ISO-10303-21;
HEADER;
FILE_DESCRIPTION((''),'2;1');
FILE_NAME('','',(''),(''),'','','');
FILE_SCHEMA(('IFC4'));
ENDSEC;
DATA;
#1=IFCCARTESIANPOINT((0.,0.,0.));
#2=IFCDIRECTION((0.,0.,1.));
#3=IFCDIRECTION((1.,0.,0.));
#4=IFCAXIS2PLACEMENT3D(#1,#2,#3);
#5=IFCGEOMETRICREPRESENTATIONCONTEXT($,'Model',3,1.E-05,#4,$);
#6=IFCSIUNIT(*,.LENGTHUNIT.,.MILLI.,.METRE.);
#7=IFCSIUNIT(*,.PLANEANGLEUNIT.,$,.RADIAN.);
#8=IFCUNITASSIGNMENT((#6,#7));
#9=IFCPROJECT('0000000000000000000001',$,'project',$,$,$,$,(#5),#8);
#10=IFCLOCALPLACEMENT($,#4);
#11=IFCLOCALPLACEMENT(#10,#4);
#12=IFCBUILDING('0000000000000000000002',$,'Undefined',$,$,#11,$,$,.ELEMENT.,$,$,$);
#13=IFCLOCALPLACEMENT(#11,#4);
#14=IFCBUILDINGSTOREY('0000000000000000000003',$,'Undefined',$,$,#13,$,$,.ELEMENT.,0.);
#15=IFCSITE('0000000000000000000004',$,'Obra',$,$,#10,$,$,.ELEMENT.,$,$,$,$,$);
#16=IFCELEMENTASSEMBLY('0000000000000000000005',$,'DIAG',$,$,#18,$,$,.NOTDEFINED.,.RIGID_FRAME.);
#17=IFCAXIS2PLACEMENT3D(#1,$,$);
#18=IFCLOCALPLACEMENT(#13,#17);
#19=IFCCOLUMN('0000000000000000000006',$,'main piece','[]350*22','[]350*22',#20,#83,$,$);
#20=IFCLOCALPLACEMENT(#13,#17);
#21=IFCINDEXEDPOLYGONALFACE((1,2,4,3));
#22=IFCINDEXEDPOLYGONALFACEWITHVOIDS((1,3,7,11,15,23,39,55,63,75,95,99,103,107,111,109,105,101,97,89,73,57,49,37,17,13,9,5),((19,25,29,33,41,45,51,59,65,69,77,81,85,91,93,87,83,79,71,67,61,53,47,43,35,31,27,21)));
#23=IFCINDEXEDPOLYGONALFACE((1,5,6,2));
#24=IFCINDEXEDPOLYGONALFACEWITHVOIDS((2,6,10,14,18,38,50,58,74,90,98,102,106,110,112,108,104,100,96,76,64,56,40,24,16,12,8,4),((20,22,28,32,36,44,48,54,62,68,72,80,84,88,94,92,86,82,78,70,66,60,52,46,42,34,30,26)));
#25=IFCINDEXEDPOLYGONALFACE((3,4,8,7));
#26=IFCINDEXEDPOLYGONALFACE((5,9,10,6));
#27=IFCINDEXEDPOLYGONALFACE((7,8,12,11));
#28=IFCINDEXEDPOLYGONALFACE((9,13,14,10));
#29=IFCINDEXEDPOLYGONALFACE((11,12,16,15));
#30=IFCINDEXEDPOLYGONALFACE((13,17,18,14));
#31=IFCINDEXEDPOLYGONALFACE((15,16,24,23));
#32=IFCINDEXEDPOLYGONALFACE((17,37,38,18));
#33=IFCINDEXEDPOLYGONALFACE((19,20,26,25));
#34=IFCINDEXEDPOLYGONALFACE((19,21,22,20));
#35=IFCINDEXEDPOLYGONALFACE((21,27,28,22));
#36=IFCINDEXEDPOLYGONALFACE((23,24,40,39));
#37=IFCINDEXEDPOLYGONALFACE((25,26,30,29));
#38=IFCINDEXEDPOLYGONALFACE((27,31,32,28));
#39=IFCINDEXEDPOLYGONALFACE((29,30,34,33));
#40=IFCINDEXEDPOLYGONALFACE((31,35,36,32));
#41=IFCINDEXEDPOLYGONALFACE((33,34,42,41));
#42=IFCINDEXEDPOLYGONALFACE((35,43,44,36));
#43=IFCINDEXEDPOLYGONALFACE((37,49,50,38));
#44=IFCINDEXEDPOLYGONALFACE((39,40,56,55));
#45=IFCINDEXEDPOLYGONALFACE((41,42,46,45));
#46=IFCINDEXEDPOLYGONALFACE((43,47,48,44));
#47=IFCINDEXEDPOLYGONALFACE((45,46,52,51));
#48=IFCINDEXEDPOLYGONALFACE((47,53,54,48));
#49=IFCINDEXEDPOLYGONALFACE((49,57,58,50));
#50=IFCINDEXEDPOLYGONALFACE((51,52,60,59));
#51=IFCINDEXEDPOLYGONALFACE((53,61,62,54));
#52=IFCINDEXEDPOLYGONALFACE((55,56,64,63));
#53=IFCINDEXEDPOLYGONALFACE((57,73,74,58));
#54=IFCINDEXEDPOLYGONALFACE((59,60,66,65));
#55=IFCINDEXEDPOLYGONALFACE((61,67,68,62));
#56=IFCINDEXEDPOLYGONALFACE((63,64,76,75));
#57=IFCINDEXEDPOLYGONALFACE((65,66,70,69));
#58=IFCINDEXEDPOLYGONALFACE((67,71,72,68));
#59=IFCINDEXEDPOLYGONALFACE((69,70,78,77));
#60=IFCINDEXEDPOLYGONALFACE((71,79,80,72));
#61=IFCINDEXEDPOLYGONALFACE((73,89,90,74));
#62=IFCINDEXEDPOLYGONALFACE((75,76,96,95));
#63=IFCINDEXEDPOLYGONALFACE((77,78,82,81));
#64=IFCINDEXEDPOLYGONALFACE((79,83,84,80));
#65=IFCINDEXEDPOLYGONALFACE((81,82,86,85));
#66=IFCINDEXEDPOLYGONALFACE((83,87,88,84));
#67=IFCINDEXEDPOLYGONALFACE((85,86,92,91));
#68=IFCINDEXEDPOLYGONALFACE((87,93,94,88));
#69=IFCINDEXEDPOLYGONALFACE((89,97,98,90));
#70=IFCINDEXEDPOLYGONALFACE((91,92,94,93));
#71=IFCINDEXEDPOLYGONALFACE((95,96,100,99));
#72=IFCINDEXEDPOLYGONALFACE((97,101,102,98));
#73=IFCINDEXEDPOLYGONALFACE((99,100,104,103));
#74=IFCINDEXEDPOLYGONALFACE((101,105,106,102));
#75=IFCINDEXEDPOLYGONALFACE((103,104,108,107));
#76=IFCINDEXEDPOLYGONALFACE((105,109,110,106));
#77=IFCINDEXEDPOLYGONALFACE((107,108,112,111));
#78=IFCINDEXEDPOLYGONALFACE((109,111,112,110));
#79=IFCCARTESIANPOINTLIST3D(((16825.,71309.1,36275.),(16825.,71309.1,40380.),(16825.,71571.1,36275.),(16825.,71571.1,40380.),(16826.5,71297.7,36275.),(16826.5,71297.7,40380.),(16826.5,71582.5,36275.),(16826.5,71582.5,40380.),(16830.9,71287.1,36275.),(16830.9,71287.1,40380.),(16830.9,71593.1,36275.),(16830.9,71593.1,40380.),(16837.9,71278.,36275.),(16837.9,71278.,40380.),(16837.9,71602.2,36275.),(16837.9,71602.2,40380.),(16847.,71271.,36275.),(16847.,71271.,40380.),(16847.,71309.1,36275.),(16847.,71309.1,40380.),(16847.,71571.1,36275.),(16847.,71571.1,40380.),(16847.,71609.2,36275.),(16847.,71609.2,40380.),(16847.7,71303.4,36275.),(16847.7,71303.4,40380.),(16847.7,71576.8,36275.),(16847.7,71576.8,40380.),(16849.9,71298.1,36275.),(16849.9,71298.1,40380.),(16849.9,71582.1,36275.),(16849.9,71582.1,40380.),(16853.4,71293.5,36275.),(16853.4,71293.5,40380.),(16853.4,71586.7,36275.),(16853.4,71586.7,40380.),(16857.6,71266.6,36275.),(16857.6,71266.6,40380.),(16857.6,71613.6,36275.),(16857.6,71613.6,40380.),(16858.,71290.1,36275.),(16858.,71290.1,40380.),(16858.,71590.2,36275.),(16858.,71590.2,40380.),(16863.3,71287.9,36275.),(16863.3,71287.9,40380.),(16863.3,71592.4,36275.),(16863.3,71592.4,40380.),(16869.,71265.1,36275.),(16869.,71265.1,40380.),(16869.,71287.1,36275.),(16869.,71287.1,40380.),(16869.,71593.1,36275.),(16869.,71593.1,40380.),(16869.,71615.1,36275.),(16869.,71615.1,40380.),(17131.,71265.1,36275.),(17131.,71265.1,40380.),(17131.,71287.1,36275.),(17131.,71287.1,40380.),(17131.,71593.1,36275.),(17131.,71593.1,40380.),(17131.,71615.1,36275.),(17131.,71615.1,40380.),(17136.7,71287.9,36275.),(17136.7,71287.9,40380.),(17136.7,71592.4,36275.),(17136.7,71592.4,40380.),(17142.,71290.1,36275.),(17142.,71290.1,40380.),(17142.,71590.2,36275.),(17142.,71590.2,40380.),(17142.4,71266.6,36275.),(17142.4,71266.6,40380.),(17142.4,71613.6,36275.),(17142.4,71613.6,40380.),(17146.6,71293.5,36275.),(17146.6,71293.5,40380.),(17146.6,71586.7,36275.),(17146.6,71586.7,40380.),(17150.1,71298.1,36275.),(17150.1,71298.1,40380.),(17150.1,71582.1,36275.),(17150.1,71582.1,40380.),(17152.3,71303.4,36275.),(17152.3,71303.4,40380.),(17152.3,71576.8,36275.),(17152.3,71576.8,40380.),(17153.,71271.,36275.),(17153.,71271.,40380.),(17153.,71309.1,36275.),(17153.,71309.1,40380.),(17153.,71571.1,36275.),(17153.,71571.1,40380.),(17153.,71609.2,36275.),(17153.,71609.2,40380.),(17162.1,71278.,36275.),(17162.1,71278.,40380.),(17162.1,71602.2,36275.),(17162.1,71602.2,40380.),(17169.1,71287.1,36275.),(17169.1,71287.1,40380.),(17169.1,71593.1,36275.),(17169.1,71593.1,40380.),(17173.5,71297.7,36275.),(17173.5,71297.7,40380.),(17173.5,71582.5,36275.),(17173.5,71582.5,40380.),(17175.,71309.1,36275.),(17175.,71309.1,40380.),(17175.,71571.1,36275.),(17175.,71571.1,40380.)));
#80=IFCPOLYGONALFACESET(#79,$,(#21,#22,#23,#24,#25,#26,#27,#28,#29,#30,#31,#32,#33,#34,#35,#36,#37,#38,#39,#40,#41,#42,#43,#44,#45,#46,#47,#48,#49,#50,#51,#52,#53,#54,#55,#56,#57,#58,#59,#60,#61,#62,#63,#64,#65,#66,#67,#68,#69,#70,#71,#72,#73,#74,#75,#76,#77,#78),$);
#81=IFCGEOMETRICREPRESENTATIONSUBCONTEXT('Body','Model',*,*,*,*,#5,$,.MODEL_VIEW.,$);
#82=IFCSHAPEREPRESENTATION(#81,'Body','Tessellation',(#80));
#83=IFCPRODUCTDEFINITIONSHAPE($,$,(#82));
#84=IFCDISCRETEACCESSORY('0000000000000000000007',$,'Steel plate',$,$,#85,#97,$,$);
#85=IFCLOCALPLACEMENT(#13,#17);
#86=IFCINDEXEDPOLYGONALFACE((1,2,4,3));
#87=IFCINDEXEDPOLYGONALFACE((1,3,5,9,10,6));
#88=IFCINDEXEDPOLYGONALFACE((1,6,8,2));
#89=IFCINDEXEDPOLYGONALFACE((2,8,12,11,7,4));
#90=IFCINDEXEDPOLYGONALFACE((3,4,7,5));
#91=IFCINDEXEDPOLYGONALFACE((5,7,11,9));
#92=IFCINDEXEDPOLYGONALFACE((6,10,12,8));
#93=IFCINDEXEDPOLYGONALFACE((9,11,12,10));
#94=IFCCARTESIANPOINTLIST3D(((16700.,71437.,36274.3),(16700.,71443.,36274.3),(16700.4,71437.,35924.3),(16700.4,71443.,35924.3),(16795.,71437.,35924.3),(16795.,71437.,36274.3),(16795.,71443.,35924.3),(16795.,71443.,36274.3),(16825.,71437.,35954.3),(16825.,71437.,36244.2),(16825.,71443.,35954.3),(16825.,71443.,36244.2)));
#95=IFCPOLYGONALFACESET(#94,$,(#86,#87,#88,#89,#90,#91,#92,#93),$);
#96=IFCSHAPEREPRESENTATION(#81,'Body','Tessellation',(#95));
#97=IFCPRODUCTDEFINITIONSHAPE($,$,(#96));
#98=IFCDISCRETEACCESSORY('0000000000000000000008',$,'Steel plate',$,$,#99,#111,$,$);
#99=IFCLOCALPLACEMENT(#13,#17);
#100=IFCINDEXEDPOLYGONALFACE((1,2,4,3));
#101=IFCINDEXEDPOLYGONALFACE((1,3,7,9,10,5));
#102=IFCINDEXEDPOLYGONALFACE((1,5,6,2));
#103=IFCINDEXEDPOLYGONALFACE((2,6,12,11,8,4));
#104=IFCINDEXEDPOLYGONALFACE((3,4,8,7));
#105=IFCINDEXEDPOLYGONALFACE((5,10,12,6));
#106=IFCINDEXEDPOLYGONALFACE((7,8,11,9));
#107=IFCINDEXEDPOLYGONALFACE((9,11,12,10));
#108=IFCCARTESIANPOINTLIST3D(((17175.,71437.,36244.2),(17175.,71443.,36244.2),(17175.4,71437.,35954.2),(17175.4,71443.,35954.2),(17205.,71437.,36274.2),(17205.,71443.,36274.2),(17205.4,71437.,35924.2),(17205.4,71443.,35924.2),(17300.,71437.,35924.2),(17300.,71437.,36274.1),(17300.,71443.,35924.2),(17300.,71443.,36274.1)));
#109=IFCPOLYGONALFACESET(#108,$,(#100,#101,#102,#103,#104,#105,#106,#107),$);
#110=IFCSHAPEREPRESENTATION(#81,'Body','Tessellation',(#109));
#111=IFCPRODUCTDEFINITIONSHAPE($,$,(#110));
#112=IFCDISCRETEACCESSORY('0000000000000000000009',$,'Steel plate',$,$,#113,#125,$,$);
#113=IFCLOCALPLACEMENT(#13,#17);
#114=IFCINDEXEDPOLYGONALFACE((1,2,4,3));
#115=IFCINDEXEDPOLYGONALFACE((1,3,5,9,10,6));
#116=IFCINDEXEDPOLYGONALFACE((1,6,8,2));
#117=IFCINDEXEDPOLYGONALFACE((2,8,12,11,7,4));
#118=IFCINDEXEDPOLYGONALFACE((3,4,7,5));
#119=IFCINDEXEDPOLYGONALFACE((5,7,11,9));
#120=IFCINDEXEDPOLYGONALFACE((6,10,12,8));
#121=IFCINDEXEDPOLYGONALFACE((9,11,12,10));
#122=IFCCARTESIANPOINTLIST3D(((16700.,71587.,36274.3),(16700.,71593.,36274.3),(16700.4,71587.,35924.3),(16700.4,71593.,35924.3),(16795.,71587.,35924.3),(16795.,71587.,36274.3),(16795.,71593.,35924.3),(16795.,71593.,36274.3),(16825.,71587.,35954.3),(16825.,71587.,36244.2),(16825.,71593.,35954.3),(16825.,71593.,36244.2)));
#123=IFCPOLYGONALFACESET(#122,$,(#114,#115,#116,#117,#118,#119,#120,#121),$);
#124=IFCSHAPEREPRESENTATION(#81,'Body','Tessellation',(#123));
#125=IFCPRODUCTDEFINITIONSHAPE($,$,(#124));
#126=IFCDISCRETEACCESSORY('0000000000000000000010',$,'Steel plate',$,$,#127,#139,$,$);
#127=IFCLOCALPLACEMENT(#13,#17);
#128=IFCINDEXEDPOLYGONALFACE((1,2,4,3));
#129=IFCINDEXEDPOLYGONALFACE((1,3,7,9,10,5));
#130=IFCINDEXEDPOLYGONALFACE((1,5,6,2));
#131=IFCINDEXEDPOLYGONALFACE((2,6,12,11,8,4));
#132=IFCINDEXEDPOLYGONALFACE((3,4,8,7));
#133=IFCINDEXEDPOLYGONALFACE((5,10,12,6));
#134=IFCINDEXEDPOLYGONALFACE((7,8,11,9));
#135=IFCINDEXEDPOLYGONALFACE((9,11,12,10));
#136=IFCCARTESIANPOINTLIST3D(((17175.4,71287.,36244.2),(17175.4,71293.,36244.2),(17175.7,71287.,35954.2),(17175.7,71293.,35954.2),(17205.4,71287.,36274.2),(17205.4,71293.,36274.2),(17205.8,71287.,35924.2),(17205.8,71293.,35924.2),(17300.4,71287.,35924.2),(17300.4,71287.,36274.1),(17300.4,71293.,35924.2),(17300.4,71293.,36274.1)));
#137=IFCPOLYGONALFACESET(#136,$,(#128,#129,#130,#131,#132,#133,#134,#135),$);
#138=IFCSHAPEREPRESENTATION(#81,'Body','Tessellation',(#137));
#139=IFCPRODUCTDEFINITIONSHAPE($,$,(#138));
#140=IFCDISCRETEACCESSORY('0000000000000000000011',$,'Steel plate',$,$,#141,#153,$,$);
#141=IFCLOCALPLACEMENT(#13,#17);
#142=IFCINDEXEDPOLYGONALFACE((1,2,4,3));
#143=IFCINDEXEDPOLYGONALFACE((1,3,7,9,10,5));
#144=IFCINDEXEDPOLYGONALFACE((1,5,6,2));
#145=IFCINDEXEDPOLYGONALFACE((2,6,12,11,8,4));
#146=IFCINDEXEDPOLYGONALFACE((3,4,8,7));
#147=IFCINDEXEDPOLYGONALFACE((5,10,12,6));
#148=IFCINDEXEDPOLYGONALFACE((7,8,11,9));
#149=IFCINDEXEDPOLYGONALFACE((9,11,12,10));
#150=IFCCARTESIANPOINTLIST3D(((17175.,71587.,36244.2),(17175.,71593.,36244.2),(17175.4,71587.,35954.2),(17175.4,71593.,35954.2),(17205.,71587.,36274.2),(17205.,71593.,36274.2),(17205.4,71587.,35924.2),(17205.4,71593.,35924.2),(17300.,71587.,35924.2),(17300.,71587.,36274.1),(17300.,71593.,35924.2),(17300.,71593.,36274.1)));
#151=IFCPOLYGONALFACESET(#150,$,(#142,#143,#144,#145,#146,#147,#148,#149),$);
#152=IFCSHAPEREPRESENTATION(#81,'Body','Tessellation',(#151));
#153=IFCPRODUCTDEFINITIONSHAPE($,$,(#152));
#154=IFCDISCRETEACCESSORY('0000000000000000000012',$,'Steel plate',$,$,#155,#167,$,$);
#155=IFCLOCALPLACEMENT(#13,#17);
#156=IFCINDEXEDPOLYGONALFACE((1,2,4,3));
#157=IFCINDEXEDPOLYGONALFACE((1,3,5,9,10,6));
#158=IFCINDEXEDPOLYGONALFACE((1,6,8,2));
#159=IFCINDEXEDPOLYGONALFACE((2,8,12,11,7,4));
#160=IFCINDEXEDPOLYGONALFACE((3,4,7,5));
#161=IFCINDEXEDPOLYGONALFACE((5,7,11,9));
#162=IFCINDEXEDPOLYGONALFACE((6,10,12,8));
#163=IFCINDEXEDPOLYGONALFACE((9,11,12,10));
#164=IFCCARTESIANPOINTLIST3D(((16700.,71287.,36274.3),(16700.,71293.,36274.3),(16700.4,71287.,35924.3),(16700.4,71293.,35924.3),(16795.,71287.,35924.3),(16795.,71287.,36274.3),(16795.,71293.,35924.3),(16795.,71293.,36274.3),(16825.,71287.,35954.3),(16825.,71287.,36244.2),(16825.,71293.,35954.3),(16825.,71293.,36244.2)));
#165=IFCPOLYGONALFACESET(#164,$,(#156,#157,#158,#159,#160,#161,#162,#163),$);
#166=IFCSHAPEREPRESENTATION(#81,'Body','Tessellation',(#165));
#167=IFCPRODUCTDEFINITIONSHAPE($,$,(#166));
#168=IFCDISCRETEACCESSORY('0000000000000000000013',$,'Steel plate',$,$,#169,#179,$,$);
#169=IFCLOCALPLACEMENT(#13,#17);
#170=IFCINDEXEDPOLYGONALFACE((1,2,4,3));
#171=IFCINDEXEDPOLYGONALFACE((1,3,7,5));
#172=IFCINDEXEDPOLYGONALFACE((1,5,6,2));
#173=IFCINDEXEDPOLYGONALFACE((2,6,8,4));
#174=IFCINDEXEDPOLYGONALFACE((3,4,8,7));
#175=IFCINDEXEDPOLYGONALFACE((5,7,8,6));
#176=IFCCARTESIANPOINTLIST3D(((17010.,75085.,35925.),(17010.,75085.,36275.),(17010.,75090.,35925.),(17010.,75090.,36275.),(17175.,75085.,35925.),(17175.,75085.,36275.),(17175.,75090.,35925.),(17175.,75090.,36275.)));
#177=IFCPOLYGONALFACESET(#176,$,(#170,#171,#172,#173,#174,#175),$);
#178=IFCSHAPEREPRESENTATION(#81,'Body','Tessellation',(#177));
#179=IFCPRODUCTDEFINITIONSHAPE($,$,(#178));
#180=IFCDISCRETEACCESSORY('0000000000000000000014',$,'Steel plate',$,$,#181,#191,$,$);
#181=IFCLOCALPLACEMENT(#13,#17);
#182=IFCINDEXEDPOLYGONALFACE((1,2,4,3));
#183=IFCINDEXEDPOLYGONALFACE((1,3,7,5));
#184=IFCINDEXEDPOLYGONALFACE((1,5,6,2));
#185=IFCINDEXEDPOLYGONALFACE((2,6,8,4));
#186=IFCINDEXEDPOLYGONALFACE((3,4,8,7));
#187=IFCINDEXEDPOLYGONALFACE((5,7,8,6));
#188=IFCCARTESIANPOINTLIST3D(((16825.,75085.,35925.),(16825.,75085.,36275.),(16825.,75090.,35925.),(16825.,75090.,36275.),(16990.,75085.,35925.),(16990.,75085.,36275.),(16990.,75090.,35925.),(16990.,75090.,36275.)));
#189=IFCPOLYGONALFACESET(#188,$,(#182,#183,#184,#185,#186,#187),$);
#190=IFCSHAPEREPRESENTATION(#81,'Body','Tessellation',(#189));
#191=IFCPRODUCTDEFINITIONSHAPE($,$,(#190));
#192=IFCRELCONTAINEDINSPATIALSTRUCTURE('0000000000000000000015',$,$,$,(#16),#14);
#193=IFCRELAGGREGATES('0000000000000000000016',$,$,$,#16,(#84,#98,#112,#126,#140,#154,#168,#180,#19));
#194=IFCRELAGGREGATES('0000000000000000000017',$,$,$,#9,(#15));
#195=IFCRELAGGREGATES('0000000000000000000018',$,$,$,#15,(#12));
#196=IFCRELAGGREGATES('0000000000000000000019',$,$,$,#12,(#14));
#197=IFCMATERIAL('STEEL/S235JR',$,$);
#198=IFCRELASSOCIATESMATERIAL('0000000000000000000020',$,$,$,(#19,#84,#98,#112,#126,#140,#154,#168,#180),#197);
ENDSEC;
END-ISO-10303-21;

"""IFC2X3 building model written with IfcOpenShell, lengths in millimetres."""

from ifc_helpers import new_model, si_unit, frame, origin_with_axes, origin_2d_with_axis, place, context, subcontext, project, spatial, polyline, hollow_rectangle, outline, extrude, material, element, aggregate, save


model = new_model("IFC2X3")

# Units and contexts
model_context = context("Model", 3, precision=1e-05, world=origin_with_axes())
body_context = subcontext(model_context, "Body", "Model", "MODEL_VIEW")
ifc_project = project(units=[si_unit("LENGTHUNIT", "METRE", prefix="MILLI"), si_unit("PLANEANGLEUNIT", "RADIAN")], contexts=[model_context])

# Site, building, storey
site_placement = place(None, origin_with_axes())
site = spatial("IfcSite", under=ifc_project, at=site_placement, Name="Obra", CompositionType="ELEMENT")
building_placement = place(site_placement, origin_with_axes())
building = spatial("IfcBuilding", under=site, at=building_placement, Name="Undefined", CompositionType="ELEMENT")
storey_placement = place(building_placement, origin_with_axes())
storey = spatial("IfcBuildingStorey", under=building, at=storey_placement, Name="Undefined", CompositionType="ELEMENT", Elevation=0.0)

# Element assembly, column
assembly_1_placement = place(storey_placement, origin_with_axes())
assembly_1 = element("IfcElementAssembly", 1, at=assembly_1_placement, inside=storey, Name="DIAG", AssemblyPlace="NOTDEFINED", PredefinedType="RIGID_FRAME")
ifc_material_1 = material(Name="STEEL/S235JR")
column_placement = place(assembly_1_placement, frame((17000.0, 71440.1, 36275.0), z_axis=(0.0, 0.0, 1.0), x_axis=(-1.0, 0.0, 0.0)))
column = element("IfcColumn", 2, at=column_placement, material=ifc_material_1, Name="main piece", Description="[]350*22", ObjectType="[]350*22", context=body_context, shape_type="SweptSolid", body=[
    extrude(hollow_rectangle(XDim=350.0, YDim=350.0, WallThickness=22.0, InnerFilletRadius=22.0, OuterFilletRadius=44.0, at=origin_2d_with_axis()), frame((0.0, 0.0, 4105.0), z_axis=(0.0, 0.0, -1.0), x_axis=(0.0, 1.0, 0.0)), (0.0, 0.0, 1.0), 4105.0),
])

# Discrete accessory
discrete_accessory_1_placement = place(assembly_1_placement, frame((16825.0, 71440.0, 35924.3), z_axis=(0.0, 1.0, 0.0), x_axis=(-1.0, 0.0, 0.0)))
discrete_accessory_1 = element("IfcDiscreteAccessory", 3, at=discrete_accessory_1_placement, material=ifc_material_1, Name="Steel plate", context=body_context, shape_type="SweptSolid", body=[
    extrude(outline(polyline([(0.0, 30.0), (30.0, 0.0), (124.6, 0.0), (125.0, 350.0), (30.0, 349.9), (0.0, 319.9), (0.0, 30.0)])), frame((0.0, 0.0, -3.0), z_axis=(0.0, 0.0, 1.0), x_axis=(1.0, 0.0, 0.0)), (0.0, 0.0, 1.0), 6.0),
])

# Discrete accessories
discrete_accessory_2_placement = place(assembly_1_placement, frame((17300.0, 71440.0, 35924.2), z_axis=(0.0, 1.0, 0.0), x_axis=(-1.0, 0.0, 0.0)))
discrete_accessory_2 = element("IfcDiscreteAccessory", 4, at=discrete_accessory_2_placement, material=ifc_material_1, Name="Steel plate", context=body_context, shape_type="SweptSolid", body=[
    extrude(outline(polyline([(0.0, 0.0), (94.6, 0.0), (124.6, 30.0), (125.0, 320.0), (95.0, 350.0), (0.0, 349.9), (0.0, 0.0)])), frame((0.0, 0.0, -3.0), z_axis=(0.0, 0.0, 1.0), x_axis=(1.0, 0.0, 0.0)), (0.0, 0.0, 1.0), 6.0),
])
discrete_accessory_3_placement = place(assembly_1_placement, frame((16825.0, 71590.0, 35924.3), z_axis=(0.0, 1.0, 0.0), x_axis=(-1.0, 0.0, 0.0)))
discrete_accessory_3 = element("IfcDiscreteAccessory", 5, at=discrete_accessory_3_placement, material=ifc_material_1, Name="Steel plate", context=body_context, shape_type="SweptSolid", body=[
    extrude(outline(polyline([(0.0, 30.0), (30.0, 0.0), (124.6, 0.0), (125.0, 350.0), (30.0, 349.9), (0.0, 319.9), (0.0, 30.0)])), frame((0.0, 0.0, -3.0), z_axis=(0.0, 0.0, 1.0), x_axis=(1.0, 0.0, 0.0)), (0.0, 0.0, 1.0), 6.0),
])
discrete_accessory_4_placement = place(assembly_1_placement, frame((17300.4, 71290.0, 35924.2), z_axis=(0.0, 1.0, 0.0), x_axis=(-1.0, 0.0, 0.0)))
discrete_accessory_4 = element("IfcDiscreteAccessory", 6, at=discrete_accessory_4_placement, material=ifc_material_1, Name="Steel plate", context=body_context, shape_type="SweptSolid", body=[
    extrude(outline(polyline([(0.0, 0.0), (94.6, 0.0), (124.6, 30.0), (125.0, 320.0), (95.0, 350.0), (0.0, 349.9), (0.0, 0.0)])), frame((0.0, 0.0, -3.0), z_axis=(0.0, 0.0, 1.0), x_axis=(1.0, 0.0, 0.0)), (0.0, 0.0, 1.0), 6.0),
])
discrete_accessory_5_placement = place(assembly_1_placement, frame((17300.0, 71590.0, 35924.2), z_axis=(0.0, 1.0, 0.0), x_axis=(-1.0, 0.0, 0.0)))
discrete_accessory_5 = element("IfcDiscreteAccessory", 7, at=discrete_accessory_5_placement, material=ifc_material_1, Name="Steel plate", context=body_context, shape_type="SweptSolid", body=[
    extrude(outline(polyline([(0.0, 0.0), (94.6, 0.0), (124.6, 30.0), (125.0, 320.0), (95.0, 350.0), (0.0, 349.9), (0.0, 0.0)])), frame((0.0, 0.0, -3.0), z_axis=(0.0, 0.0, 1.0), x_axis=(1.0, 0.0, 0.0)), (0.0, 0.0, 1.0), 6.0),
])
discrete_accessory_6_placement = place(assembly_1_placement, frame((16825.0, 71290.0, 35924.3), z_axis=(0.0, 1.0, 0.0), x_axis=(-1.0, 0.0, 0.0)))
discrete_accessory_6 = element("IfcDiscreteAccessory", 8, at=discrete_accessory_6_placement, material=ifc_material_1, Name="Steel plate", context=body_context, shape_type="SweptSolid", body=[
    extrude(outline(polyline([(0.0, 30.0), (30.0, 0.0), (124.6, 0.0), (125.0, 350.0), (30.0, 349.9), (0.0, 319.9), (0.0, 30.0)])), frame((0.0, 0.0, -3.0), z_axis=(0.0, 0.0, 1.0), x_axis=(1.0, 0.0, 0.0)), (0.0, 0.0, 1.0), 6.0),
])

# Discrete accessories
discrete_accessory_7_placement = place(assembly_1_placement, frame((17175.0, 75087.5, 35925.0), z_axis=(0.0, 1.0, 0.0), x_axis=(-1.0, 0.0, 0.0)))
discrete_accessory_7 = element("IfcDiscreteAccessory", 9, at=discrete_accessory_7_placement, material=ifc_material_1, Name="Steel plate", context=body_context, shape_type="SweptSolid", body=[
    extrude(outline(polyline([(0.0, 0.0), (165.0, 0.0), (165.0, 350.0), (0.0, 350.0), (0.0, 0.0)])), frame((0.0, 0.0, -2.5), z_axis=(0.0, 0.0, 1.0), x_axis=(1.0, 0.0, 0.0)), (0.0, 0.0, 1.0), 5.0),
])
discrete_accessory_8_placement = place(assembly_1_placement, frame((16990.0, 75087.5, 35925.0), z_axis=(0.0, 1.0, 0.0), x_axis=(-1.0, 0.0, 0.0)))
discrete_accessory_8 = element("IfcDiscreteAccessory", 10, at=discrete_accessory_8_placement, material=ifc_material_1, Name="Steel plate", context=body_context, shape_type="SweptSolid", body=[
    extrude(outline(polyline([(0.0, 0.0), (165.0, 0.0), (165.0, 350.0), (0.0, 350.0), (0.0, 0.0)])), frame((0.0, 0.0, -2.5), z_axis=(0.0, 0.0, 1.0), x_axis=(1.0, 0.0, 0.0)), (0.0, 0.0, 1.0), 5.0),
])
aggregate(assembly_1, [discrete_accessory_1, discrete_accessory_2, discrete_accessory_3, discrete_accessory_4, discrete_accessory_5, discrete_accessory_6, discrete_accessory_7, discrete_accessory_8, column])

save(model, "model.ifc")
